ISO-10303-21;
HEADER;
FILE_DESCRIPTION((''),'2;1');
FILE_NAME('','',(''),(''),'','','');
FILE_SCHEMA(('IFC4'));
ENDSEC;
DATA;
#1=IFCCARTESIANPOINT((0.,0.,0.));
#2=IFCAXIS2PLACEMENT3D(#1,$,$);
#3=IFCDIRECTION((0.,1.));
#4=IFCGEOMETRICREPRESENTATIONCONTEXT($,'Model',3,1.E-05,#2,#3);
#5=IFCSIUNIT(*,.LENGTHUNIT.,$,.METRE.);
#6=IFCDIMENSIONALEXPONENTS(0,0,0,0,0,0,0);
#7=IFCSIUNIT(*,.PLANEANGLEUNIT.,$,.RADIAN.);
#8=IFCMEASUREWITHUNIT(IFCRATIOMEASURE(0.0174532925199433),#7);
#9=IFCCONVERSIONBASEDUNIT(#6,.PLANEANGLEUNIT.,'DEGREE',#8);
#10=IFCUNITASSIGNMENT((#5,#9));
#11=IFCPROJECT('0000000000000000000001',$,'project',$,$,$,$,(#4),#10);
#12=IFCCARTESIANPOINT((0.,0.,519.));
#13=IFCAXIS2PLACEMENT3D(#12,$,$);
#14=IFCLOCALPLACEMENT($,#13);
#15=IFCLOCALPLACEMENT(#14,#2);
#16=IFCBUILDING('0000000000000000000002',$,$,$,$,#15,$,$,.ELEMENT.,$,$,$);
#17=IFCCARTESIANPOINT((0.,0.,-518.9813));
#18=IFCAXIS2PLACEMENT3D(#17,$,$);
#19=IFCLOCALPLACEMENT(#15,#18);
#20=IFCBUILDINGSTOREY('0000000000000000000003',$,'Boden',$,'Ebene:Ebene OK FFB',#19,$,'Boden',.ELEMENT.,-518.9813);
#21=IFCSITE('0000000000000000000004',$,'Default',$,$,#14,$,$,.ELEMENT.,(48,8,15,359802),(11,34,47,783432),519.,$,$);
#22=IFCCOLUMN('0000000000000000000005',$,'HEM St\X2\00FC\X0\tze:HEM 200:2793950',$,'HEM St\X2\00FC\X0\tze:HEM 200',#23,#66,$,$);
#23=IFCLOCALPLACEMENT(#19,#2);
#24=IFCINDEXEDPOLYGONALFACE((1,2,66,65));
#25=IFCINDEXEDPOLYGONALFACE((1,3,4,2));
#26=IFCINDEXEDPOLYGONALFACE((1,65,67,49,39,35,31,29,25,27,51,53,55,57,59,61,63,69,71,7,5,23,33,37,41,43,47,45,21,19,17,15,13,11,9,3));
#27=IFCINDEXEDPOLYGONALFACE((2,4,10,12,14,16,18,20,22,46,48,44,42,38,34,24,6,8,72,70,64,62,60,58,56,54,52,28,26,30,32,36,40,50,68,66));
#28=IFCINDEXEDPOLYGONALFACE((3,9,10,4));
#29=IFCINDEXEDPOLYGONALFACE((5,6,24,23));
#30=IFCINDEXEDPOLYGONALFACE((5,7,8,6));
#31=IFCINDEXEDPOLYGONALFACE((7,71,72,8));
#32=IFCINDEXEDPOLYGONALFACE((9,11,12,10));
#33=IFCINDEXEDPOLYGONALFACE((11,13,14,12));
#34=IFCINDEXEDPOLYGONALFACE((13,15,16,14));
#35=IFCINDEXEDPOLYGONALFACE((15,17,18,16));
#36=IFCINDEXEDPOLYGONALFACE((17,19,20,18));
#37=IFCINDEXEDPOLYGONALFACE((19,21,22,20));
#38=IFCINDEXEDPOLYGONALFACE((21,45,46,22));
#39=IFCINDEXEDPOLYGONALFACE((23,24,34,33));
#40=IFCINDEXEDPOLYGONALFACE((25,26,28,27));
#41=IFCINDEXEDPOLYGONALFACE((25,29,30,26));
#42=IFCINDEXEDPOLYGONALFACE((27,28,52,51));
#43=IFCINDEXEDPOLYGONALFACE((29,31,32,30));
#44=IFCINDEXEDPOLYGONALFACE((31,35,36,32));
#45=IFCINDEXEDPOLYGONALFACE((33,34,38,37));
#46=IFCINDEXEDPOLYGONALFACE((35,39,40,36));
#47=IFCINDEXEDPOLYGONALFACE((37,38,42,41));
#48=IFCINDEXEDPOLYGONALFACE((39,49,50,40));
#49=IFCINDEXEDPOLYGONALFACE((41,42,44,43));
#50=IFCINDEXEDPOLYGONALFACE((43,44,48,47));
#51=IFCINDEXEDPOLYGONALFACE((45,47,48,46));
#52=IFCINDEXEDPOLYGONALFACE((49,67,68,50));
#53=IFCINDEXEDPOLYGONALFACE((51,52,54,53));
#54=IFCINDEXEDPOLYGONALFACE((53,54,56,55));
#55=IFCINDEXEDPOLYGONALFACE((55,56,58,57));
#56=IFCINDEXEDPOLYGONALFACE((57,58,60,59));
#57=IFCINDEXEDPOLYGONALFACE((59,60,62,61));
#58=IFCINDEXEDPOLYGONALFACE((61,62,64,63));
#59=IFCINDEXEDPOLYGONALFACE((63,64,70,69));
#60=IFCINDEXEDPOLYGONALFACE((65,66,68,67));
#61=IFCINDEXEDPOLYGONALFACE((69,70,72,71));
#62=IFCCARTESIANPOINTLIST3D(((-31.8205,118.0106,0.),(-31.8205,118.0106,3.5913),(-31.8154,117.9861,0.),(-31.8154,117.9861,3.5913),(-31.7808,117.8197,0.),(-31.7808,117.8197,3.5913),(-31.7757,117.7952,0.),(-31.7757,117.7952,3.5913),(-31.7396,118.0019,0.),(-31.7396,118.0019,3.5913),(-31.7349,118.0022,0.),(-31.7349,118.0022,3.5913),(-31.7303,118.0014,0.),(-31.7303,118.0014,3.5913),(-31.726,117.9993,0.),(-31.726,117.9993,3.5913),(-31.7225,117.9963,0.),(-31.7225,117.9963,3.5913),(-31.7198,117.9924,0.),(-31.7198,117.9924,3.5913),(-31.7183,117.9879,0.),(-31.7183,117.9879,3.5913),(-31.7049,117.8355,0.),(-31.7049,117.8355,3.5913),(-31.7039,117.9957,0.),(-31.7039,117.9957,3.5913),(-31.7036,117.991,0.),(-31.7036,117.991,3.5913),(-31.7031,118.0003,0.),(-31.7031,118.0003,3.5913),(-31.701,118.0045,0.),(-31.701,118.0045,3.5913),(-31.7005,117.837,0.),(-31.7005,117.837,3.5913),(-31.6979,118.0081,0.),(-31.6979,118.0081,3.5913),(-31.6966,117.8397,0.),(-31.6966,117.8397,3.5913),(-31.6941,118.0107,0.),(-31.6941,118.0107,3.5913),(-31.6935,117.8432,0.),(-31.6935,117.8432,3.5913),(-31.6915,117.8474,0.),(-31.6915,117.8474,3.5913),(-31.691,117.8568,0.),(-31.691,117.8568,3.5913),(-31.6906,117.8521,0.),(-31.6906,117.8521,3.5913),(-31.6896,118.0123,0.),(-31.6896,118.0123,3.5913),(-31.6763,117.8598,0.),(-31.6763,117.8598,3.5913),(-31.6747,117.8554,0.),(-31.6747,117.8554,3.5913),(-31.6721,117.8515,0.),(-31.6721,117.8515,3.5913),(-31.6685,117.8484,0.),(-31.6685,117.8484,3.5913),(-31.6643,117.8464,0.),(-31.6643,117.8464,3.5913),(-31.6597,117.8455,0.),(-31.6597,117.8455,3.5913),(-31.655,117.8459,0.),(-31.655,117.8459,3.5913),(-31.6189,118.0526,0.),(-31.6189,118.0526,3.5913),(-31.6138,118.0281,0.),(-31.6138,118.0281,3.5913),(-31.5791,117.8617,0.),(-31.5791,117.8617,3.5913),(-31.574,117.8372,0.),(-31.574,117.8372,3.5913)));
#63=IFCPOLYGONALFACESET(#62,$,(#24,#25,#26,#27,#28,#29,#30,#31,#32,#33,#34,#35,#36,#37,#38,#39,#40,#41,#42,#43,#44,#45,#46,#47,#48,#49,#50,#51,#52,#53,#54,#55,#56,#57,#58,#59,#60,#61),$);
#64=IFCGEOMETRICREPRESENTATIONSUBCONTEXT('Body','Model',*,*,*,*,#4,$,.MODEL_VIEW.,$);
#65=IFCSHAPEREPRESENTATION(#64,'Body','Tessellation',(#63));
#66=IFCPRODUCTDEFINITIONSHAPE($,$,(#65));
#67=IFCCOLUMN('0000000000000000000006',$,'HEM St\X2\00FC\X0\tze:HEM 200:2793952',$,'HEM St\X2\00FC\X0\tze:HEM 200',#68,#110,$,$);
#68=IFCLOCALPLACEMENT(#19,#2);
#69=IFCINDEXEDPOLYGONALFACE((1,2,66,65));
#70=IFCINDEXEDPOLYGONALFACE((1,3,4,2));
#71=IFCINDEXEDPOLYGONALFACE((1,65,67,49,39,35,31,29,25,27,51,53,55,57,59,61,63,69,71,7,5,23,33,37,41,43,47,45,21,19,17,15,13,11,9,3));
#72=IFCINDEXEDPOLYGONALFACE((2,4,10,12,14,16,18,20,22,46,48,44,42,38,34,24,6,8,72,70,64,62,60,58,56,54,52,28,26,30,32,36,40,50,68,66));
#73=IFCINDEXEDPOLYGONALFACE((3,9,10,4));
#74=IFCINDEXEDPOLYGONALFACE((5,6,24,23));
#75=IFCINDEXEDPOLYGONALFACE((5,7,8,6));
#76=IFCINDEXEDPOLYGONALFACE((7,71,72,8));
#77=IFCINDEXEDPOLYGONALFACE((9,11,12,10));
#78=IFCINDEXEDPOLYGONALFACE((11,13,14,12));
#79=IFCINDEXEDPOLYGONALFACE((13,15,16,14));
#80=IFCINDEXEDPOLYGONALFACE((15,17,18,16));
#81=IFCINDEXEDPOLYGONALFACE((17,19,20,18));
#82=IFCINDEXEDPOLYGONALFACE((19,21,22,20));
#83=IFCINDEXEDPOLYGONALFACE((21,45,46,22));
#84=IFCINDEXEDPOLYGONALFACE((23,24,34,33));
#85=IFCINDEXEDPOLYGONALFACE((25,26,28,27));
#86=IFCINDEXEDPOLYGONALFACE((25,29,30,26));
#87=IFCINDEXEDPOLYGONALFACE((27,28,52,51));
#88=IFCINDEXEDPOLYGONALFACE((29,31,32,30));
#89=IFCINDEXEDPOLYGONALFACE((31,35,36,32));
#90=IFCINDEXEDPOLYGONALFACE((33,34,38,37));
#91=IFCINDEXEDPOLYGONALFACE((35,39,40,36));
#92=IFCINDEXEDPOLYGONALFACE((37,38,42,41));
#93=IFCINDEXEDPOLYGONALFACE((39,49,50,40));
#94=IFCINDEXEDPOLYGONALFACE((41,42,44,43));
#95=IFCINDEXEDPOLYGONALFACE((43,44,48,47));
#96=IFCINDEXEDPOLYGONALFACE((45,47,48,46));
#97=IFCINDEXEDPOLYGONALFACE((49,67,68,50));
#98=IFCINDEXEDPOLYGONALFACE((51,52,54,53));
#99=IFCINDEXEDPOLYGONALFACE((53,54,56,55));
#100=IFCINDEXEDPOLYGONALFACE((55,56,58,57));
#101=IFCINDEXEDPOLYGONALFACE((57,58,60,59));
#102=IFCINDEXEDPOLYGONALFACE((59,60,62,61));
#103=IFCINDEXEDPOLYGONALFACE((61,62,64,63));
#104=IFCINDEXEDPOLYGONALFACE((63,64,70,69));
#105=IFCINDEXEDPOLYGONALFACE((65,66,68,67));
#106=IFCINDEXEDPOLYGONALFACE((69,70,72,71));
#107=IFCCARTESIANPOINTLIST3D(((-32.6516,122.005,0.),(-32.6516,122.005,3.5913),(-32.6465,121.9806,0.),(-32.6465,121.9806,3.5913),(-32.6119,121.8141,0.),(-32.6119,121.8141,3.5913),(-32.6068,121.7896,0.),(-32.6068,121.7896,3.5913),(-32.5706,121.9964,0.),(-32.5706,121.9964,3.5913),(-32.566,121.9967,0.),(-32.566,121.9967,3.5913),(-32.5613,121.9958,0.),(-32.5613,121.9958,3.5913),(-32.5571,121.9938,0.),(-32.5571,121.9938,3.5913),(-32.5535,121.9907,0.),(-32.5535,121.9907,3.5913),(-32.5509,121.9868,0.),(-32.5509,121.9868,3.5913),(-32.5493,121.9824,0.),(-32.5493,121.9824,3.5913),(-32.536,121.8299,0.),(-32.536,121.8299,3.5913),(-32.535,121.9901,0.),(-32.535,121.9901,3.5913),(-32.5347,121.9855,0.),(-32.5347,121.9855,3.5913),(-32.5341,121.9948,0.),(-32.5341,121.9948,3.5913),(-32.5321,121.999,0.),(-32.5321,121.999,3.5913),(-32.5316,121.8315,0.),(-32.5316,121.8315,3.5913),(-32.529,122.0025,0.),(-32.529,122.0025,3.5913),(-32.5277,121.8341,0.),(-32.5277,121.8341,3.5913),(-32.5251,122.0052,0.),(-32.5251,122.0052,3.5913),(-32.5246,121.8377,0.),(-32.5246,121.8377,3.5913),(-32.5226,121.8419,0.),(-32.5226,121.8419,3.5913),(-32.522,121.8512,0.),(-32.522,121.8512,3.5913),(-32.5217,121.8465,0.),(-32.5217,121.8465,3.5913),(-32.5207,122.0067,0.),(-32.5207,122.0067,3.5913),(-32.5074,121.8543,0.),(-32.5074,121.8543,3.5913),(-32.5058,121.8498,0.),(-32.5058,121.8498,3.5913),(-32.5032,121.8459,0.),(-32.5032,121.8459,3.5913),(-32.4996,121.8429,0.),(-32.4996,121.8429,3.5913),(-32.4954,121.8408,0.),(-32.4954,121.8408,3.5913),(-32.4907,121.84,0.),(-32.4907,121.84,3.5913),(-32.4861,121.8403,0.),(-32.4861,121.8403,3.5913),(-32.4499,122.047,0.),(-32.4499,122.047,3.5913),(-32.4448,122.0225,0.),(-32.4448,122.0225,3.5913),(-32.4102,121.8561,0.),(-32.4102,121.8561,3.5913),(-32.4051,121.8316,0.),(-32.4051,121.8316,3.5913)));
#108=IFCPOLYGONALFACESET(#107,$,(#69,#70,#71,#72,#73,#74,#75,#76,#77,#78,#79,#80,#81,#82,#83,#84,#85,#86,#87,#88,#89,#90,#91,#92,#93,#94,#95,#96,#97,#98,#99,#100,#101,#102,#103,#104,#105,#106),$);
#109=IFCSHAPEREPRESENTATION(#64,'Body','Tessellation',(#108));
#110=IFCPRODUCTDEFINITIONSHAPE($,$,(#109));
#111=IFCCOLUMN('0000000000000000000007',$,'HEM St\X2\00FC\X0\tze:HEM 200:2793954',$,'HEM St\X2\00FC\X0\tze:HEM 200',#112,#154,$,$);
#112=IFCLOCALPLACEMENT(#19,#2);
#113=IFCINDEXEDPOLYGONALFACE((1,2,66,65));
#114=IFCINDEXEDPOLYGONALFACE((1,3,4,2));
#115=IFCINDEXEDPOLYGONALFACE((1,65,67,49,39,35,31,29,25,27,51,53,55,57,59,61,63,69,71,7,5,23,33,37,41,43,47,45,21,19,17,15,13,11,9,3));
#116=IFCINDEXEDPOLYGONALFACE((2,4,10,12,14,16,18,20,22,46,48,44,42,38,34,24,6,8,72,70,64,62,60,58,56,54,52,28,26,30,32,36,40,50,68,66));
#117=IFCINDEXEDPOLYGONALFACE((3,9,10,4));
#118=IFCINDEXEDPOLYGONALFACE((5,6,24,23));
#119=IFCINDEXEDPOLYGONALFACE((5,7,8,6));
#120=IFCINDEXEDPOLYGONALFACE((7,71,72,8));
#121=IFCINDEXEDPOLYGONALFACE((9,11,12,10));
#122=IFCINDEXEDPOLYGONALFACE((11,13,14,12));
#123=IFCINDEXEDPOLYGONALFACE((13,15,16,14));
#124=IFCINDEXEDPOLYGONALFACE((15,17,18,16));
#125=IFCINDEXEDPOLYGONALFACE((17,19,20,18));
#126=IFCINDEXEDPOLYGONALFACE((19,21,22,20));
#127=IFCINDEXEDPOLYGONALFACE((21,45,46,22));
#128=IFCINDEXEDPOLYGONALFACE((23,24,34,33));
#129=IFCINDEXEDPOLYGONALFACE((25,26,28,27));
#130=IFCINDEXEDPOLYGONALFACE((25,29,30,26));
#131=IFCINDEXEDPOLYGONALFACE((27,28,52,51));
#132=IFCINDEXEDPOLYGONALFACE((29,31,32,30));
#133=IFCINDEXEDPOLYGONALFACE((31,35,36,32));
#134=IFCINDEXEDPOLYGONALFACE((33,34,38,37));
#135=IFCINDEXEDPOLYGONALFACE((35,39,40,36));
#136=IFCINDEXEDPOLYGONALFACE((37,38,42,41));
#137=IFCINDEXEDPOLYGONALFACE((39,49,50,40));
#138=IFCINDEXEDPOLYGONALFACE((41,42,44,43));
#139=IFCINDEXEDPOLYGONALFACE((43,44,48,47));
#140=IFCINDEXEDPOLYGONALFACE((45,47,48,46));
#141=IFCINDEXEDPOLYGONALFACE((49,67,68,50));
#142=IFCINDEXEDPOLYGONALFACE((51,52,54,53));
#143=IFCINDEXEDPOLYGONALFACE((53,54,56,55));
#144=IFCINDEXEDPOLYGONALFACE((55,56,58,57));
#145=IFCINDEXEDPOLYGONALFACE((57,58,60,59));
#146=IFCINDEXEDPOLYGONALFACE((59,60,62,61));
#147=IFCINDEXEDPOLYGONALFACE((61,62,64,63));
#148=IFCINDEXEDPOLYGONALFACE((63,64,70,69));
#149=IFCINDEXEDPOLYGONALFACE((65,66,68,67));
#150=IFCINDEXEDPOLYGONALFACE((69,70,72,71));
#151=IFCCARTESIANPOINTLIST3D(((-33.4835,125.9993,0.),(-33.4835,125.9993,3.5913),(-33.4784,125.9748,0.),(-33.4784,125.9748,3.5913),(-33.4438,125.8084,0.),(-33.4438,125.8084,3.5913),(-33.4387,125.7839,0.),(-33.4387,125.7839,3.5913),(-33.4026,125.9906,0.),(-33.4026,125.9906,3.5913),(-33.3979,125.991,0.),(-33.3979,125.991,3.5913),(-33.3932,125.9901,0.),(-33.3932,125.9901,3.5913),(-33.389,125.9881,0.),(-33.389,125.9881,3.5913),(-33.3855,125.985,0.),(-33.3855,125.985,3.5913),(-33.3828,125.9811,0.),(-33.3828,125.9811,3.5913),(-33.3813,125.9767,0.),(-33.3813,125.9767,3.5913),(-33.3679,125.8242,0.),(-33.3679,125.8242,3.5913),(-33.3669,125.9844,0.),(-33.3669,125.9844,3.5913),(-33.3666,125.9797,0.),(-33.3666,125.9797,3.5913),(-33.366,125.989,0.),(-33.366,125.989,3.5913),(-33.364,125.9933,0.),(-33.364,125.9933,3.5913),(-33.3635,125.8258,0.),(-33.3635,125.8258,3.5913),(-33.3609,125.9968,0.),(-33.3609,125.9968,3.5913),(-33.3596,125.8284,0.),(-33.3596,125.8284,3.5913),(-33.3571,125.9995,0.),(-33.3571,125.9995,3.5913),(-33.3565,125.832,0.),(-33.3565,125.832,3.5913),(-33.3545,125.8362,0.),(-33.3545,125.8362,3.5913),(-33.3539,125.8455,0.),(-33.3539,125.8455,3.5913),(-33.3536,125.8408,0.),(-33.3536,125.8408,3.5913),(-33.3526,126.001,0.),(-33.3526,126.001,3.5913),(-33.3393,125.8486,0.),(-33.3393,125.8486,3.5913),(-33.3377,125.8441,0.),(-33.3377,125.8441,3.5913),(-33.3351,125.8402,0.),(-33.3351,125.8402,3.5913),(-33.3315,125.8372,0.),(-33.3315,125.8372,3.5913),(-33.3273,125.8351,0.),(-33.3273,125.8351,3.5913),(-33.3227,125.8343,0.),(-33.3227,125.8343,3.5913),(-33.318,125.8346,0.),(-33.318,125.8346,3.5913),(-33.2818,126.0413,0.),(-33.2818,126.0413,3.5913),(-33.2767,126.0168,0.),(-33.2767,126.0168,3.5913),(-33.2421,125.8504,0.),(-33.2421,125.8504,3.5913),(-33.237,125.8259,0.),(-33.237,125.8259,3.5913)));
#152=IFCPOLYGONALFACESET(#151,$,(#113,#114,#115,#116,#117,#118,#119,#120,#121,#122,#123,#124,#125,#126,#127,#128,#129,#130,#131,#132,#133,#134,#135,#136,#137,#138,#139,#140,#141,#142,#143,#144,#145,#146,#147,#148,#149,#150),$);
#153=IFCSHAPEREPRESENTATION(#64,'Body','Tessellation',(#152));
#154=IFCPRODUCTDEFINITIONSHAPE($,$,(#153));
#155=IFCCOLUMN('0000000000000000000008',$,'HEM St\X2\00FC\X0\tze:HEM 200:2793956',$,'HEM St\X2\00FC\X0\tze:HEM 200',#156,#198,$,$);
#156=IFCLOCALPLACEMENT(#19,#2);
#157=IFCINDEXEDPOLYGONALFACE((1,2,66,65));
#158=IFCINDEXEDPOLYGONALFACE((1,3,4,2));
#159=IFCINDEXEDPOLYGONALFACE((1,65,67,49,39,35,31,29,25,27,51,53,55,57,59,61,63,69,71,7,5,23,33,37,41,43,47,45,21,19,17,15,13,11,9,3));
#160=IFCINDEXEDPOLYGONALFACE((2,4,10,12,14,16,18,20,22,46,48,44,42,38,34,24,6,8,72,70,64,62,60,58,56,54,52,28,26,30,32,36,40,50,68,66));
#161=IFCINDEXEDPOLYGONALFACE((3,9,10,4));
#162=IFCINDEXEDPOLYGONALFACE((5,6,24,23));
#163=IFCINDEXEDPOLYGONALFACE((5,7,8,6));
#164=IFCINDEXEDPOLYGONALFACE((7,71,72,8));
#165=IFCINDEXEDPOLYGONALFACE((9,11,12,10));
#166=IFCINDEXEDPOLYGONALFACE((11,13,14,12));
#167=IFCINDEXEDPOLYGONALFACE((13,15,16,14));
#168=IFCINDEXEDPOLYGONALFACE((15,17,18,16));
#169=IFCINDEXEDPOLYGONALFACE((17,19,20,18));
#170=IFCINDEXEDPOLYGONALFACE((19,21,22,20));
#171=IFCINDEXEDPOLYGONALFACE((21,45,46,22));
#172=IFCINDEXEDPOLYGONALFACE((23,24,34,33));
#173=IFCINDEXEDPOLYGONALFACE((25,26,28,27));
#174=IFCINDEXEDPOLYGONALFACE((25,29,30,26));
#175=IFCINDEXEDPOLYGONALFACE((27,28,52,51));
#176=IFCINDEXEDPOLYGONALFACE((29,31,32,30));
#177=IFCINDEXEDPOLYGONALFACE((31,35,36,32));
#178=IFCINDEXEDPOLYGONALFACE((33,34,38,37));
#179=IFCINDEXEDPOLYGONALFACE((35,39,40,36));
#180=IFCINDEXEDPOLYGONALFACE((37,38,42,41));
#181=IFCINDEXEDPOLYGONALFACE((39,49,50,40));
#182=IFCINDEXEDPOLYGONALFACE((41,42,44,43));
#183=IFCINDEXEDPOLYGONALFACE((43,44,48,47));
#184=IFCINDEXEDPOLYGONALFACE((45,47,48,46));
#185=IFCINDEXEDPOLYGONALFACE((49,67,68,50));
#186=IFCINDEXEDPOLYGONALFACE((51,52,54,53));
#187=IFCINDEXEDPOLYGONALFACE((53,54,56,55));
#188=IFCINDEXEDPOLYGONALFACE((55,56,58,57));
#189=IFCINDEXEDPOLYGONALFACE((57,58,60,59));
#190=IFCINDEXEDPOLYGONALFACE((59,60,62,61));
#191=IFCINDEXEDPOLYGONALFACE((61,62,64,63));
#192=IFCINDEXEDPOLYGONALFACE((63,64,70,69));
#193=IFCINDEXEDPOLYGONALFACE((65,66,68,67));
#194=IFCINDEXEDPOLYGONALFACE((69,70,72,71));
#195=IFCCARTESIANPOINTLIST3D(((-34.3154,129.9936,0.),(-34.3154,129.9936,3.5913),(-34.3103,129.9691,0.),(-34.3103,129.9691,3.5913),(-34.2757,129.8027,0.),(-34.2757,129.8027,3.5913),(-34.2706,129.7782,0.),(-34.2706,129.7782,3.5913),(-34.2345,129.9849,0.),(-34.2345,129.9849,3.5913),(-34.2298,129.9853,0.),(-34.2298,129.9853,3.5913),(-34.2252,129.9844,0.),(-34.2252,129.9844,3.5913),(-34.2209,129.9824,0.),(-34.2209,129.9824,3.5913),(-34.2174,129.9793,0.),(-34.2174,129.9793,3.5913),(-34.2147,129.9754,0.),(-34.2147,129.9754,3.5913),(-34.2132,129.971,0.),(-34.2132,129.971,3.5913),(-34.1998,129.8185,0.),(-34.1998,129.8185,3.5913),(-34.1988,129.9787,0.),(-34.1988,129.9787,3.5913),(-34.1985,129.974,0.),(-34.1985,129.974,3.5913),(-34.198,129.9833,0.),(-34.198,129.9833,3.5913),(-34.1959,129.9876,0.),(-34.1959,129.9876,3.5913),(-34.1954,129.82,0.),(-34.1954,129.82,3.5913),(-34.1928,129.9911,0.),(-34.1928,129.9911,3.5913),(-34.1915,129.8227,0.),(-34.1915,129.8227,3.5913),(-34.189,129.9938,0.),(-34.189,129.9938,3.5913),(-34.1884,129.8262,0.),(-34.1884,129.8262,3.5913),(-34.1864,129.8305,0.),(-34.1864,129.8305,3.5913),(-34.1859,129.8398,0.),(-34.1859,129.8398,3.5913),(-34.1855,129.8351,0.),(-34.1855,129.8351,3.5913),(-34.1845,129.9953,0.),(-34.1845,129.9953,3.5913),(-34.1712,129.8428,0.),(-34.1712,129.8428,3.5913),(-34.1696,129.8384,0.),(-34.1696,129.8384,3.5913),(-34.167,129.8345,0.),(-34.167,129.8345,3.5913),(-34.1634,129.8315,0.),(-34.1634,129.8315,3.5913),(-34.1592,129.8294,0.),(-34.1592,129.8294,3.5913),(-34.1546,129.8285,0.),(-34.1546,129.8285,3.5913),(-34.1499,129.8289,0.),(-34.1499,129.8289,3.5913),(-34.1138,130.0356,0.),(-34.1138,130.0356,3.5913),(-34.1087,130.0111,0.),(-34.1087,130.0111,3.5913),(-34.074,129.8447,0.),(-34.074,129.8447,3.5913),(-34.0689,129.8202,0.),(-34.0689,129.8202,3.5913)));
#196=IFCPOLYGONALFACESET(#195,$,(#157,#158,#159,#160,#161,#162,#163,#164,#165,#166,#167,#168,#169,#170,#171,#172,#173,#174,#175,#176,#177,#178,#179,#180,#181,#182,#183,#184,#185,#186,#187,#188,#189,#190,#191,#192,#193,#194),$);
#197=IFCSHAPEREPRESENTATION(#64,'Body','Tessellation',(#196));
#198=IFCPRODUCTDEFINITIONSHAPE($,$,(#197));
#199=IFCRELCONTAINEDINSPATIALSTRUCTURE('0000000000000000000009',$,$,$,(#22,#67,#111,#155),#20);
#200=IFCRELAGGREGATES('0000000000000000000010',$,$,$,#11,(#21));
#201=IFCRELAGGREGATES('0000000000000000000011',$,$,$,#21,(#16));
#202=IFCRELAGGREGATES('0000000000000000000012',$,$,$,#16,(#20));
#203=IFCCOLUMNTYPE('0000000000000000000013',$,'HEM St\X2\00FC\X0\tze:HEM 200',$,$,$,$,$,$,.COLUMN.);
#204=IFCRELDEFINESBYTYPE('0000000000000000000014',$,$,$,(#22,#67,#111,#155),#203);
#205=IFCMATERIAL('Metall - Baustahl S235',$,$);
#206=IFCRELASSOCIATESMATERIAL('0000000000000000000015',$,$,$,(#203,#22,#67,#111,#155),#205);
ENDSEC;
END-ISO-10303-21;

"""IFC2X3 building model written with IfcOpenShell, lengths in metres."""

from ifc_helpers import new_model, entity, si_unit, converted_unit, direction, frame, frame_2d, origin, place, context, subcontext, project, spatial, polyline, circle_curve, parameter, trimmed, segment, composite_curve, outline, extrude, source, transform, mapped, material, type_object, type_shapes, element, save


model = new_model("IFC2X3")

# Units and contexts
model_context = context("Model", 3, precision=1e-05, world=origin(), true_north=direction((0.0, 1.0)))
body_context = subcontext(model_context, "Body", "Model", "MODEL_VIEW")
ifc_project = project(units=[si_unit("LENGTHUNIT", "METRE"), converted_unit("PLANEANGLEUNIT", "DEGREE", entity("IfcRatioMeasure", 0.0174532925199433), si_unit("PLANEANGLEUNIT", "RADIAN"), dimensions=[0, 0, 0, 0, 0, 0, 0])], contexts=[model_context])

# Site, building, storey
site_placement = place(None, frame((0.0, 0.0, 519.0)))
site = spatial("IfcSite", under=ifc_project, at=site_placement, Name="Default", CompositionType="ELEMENT", RefLatitude=(48, 8, 15, 359802), RefLongitude=(11, 34, 47, 783432), RefElevation=519.0)
building_placement = place(site_placement, origin())
building = spatial("IfcBuilding", under=site, at=building_placement, CompositionType="ELEMENT")
storey_placement = place(building_placement, frame((0.0, 0.0, -518.9813)))
storey = spatial("IfcBuildingStorey", under=building, at=storey_placement, Name="Boden", ObjectType="Ebene:Ebene OK FFB", LongName="Boden", CompositionType="ELEMENT", Elevation=-518.9813)

# Columns
ifc_material = material(Name="Metall - Baustahl S235")
column_type = type_object("IfcColumnType", Name="HEM Stütze:HEM 200", PredefinedType="COLUMN", material=ifc_material)
shared_shape = source(origin(), body_context, "Body", "SweptSolid", [
    extrude(outline(composite_curve([segment(polyline([(0.085, -0.103), (0.11, -0.103)]), True, "CONTINUOUS"), segment(polyline([(0.11, -0.103), (0.11, 0.103)]), True, "CONTINUOUS"), segment(polyline([(0.11, 0.103), (0.085, 0.103)]), True, "CONTINUOUS"), segment(polyline([(0.085, 0.103), (0.085, 0.0255)]), True, "CONTINUOUS"), segment(trimmed(circle_curve(frame_2d((0.067, 0.0255), x_axis=(1.0, 0.0)), 0.018), [parameter(270.0)], [parameter(0.0)], True, "PARAMETER"), False, "CONTINUOUS"), segment(polyline([(0.067, 0.0075), (-0.067, 0.0075)]), True, "CONTINUOUS"), segment(trimmed(circle_curve(frame_2d((-0.067, 0.0255), x_axis=(0.0, -1.0)), 0.018), [parameter(270.0)], [parameter(0.0)], True, "PARAMETER"), False, "CONTINUOUS"), segment(polyline([(-0.085, 0.0255), (-0.085, 0.103)]), True, "CONTINUOUS"), segment(polyline([(-0.085, 0.103), (-0.11, 0.103)]), True, "CONTINUOUS"), segment(polyline([(-0.11, 0.103), (-0.11, -0.103)]), True, "CONTINUOUS"), segment(polyline([(-0.11, -0.103), (-0.085, -0.103)]), True, "CONTINUOUS"), segment(polyline([(-0.085, -0.103), (-0.085, -0.0255)]), True, "CONTINUOUS"), segment(trimmed(circle_curve(frame_2d((-0.067, -0.0255), x_axis=(-1.0, 0.0)), 0.018), [parameter(270.0)], [parameter(0.0)], True, "PARAMETER"), False, "CONTINUOUS"), segment(polyline([(-0.067, -0.0075), (0.067, -0.0075)]), True, "CONTINUOUS"), segment(trimmed(circle_curve(frame_2d((0.067, -0.0255), x_axis=(0.0, 1.0)), 0.018), [parameter(270.0)], [parameter(0.0)], True, "PARAMETER"), False, "CONTINUOUS"), segment(polyline([(0.085, -0.0255), (0.085, -0.103)]), True, "CONTINUOUS")], self_intersect=False)), frame((0.0, 0.0, -518.9813), z_axis=(0.0, 0.0, 1.0), x_axis=(0.0, -1.0, 0.0)), (0.0, 0.0, 1.0), 3.5913),
])
type_shapes(column_type, [shared_shape])
for number, where, z_axis, x_axis, name in (
    (1, (-31.6973, 117.9239, 518.9813), (0.0, 0.0, 1.0), (0.979008, 0.20382, 0.0), "HEM Stütze:HEM 200:2793950"),
    (2, (-32.5284, 121.9183, 518.9813), (0.0, 0.0, 1.0), (0.979008, 0.20382, 0.0), "HEM Stütze:HEM 200:2793952"),
    (3, (-33.3603, 125.9126, 518.9813), (0.0, 0.0, 1.0), (0.979008, 0.20382, 0.0), "HEM Stütze:HEM 200:2793954"),
    (4, (-34.1922, 129.9069, 518.9813), (0.0, 0.0, 1.0), (0.979008, 0.20382, 0.0), "HEM Stütze:HEM 200:2793956"),
):
    element("IfcColumn", number, at=place(storey_placement, frame(where, z_axis=z_axis, x_axis=x_axis)), inside=storey, type_object=column_type, material=ifc_material, Name=name, ObjectType="HEM Stütze:HEM 200", context=body_context, shape_type="MappedRepresentation", body=[
        mapped(shared_shape, transform((0.0, 0.0, 0.0), scale=1.0)),
    ])

save(model, "model.ifc")
